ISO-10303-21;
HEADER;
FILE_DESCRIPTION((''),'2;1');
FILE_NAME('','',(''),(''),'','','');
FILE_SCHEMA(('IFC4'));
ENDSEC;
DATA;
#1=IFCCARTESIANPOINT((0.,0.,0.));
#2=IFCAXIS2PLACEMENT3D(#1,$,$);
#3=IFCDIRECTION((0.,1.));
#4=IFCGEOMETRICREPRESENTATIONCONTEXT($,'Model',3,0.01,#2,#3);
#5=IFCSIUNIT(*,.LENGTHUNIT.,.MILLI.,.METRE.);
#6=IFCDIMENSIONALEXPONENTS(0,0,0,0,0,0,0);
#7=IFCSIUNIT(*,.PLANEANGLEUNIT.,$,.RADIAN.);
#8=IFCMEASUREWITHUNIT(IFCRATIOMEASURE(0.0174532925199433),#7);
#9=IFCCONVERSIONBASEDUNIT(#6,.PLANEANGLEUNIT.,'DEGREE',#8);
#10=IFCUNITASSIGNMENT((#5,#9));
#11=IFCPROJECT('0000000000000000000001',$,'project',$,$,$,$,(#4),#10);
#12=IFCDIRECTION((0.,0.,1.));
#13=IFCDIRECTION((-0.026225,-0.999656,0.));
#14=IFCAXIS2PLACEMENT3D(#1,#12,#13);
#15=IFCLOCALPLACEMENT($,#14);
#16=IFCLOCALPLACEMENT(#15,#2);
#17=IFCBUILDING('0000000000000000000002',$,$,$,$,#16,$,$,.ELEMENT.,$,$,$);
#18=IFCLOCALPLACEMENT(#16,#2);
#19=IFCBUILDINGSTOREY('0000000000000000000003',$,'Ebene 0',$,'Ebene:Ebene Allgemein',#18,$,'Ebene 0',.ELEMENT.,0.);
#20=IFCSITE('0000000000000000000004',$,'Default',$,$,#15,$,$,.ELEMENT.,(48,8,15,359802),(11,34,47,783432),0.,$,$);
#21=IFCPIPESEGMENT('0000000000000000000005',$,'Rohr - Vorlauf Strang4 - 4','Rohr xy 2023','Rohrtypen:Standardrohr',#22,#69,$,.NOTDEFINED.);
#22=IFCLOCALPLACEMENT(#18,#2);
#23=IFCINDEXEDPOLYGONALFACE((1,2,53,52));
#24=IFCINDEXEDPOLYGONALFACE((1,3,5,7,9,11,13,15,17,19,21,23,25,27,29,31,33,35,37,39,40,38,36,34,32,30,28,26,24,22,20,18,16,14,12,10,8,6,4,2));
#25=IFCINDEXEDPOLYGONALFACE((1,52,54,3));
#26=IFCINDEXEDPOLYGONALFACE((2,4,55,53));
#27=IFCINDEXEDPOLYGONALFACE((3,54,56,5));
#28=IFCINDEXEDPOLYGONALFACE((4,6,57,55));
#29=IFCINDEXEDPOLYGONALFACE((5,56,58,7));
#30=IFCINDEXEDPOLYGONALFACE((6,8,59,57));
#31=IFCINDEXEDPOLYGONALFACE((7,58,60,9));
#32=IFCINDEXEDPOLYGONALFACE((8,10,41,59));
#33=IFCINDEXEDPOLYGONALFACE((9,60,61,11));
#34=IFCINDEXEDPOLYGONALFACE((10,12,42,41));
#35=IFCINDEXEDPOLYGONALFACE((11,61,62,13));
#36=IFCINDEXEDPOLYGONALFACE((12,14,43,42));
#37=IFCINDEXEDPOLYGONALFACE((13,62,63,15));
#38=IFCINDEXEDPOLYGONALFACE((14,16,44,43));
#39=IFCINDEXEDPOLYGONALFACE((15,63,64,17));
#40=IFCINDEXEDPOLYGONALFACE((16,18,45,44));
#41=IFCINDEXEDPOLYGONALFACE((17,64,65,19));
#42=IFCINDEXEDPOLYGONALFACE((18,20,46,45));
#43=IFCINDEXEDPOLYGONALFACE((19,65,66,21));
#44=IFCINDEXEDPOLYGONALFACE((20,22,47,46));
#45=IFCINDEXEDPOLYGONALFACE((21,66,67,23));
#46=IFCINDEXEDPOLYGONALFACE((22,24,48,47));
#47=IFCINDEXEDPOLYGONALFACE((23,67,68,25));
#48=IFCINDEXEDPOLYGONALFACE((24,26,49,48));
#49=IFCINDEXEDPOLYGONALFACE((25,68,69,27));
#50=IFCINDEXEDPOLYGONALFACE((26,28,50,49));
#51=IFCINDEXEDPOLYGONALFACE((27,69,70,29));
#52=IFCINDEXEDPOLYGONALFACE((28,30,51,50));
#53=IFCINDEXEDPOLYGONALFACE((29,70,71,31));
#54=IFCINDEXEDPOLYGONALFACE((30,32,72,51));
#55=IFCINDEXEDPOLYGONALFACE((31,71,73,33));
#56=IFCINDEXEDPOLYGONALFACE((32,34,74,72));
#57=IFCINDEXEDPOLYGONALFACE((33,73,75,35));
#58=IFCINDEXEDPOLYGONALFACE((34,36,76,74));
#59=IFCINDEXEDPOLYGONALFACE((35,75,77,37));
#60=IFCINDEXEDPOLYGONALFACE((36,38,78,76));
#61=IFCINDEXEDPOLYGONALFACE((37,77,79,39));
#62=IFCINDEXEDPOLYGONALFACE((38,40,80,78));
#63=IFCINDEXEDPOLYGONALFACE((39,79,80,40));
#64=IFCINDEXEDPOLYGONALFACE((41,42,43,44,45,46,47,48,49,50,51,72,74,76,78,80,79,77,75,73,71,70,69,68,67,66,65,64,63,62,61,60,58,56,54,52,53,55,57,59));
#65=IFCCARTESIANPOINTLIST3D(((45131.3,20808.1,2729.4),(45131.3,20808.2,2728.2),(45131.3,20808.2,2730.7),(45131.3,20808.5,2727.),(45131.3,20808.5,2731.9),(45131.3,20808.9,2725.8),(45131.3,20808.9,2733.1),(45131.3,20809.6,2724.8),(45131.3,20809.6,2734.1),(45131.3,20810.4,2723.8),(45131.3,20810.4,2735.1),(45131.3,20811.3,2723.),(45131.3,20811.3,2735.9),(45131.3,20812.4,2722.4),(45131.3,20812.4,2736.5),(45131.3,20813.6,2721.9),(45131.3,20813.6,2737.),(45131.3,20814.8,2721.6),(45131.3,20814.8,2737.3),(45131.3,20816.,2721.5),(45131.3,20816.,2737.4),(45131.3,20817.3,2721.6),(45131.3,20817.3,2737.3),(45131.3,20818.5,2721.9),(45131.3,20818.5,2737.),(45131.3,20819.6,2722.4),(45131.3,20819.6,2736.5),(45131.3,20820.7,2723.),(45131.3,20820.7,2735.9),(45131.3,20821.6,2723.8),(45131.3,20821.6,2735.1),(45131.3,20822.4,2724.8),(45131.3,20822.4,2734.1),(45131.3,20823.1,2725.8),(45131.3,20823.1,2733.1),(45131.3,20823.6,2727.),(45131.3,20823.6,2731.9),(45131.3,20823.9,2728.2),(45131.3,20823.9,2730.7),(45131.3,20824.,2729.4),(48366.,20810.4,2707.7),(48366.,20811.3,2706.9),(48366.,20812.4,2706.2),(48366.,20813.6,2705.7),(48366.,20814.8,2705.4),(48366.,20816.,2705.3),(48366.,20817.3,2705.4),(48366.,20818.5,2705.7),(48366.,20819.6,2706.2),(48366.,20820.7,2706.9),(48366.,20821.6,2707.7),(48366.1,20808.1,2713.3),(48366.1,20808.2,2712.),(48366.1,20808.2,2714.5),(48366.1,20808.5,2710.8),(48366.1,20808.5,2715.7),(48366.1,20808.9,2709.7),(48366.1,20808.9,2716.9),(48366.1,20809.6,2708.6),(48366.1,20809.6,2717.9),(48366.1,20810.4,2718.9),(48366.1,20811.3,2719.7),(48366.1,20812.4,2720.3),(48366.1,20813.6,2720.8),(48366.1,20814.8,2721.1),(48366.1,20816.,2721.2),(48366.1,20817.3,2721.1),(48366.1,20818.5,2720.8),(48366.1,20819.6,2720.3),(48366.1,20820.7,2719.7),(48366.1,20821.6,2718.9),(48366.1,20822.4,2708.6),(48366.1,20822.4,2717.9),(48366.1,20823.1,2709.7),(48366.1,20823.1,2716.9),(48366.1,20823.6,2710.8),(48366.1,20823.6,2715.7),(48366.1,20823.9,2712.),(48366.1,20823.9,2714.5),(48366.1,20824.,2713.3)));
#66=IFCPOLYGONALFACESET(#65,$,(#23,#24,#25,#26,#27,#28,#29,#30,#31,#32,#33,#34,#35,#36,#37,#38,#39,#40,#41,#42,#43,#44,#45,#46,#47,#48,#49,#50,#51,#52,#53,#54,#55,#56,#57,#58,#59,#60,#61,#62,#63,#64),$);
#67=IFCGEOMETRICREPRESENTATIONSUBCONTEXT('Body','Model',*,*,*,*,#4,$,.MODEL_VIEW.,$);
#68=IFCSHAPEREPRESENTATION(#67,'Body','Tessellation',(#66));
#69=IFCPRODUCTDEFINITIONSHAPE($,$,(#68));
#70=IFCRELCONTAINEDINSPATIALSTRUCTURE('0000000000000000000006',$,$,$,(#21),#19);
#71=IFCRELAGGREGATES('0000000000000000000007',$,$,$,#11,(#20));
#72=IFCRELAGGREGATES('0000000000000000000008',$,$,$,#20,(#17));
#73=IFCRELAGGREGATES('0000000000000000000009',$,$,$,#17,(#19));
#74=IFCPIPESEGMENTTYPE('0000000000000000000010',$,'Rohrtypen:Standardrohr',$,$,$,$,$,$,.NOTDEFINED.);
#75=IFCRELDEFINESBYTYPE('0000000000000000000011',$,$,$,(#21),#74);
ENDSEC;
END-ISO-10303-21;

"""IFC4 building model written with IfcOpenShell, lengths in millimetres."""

from ifc_helpers import new_model, entity, si_unit, converted_unit, direction, frame, origin, place, context, subcontext, project, spatial, indexed_curve, outline, extrude, type_object, element, save


model = new_model("IFC4")

# Units and contexts
model_context = context("Model", 3, precision=0.01, world=origin(), true_north=direction((0.0, 1.0)))
body_context = subcontext(model_context, "Body", "Model", "MODEL_VIEW")
ifc_project = project(units=[si_unit("LENGTHUNIT", "METRE", prefix="MILLI"), converted_unit("PLANEANGLEUNIT", "DEGREE", entity("IfcRatioMeasure", 0.0174532925199433), si_unit("PLANEANGLEUNIT", "RADIAN"), dimensions=[0, 0, 0, 0, 0, 0, 0])], contexts=[model_context])

# Site, building, storey
site_placement = place(None, frame((0.0, 0.0, 0.0), z_axis=(0.0, 0.0, 1.0), x_axis=(-0.026225, -0.999656, 0.0)))
site = spatial("IfcSite", under=ifc_project, at=site_placement, Name="Default", CompositionType="ELEMENT", RefLatitude=(48, 8, 15, 359802), RefLongitude=(11, 34, 47, 783432), RefElevation=0.0)
building_placement = place(site_placement, origin())
building = spatial("IfcBuilding", under=site, at=building_placement, CompositionType="ELEMENT")
storey_placement = place(building_placement, origin())
storey = spatial("IfcBuildingStorey", under=building, at=storey_placement, Name="Ebene 0", ObjectType="Ebene:Ebene Allgemein", LongName="Ebene 0", CompositionType="ELEMENT", Elevation=0.0)

# Pipe segment
pipe_segment_type = type_object("IfcPipeSegmentType", Name="Rohrtypen:Standardrohr", PredefinedType="NOTDEFINED")
pipe_segment_1_placement = place(storey_placement, origin())
element("IfcPipeSegment", 1, at=pipe_segment_1_placement, inside=storey, type_object=pipe_segment_type, Name="Rohr - Vorlauf Strang4 - 4", Description="Rohr xy 2023", ObjectType="Rohrtypen:Standardrohr", PredefinedType="NOTDEFINED", context=body_context, shape_type="SweptSolid", body=[
    extrude(outline(indexed_curve([(7.9, 0.0), (7.8, 1.2), (7.6, 2.5), (7.1, 3.6), (6.4, 4.7), (5.6, 5.6), (4.7, 6.4), (3.6, 7.1), (2.5, 7.6), (1.2, 7.8), (0.0, 7.9), (-1.2, 7.8), (-2.5, 7.6), (-3.6, 7.1), (-4.7, 6.4), (-5.6, 5.6), (-6.4, 4.7), (-7.1, 3.6), (-7.6, 2.5), (-7.8, 1.2), (-7.9, 0.0), (-7.8, -1.2), (-7.6, -2.5), (-7.1, -3.6), (-6.4, -4.7), (-5.6, -5.6), (-4.7, -6.4), (-3.6, -7.1), (-2.5, -7.6), (-1.2, -7.8), (0.0, -7.9), (1.2, -7.8), (2.5, -7.6), (3.6, -7.1), (4.7, -6.4), (5.6, -5.6), (6.4, -4.7), (7.1, -3.6), (7.6, -2.5), (7.8, -1.2), (7.9, 0.0)], self_intersect=False)), frame((48366.1, 20816.0, 2713.3), z_axis=(-0.999988, 0.0, 0.005), x_axis=(0.0, 1.0, 0.0)), (0.0, 0.0, 1.0), 3234.8),
])

save(model, "model.ifc")
